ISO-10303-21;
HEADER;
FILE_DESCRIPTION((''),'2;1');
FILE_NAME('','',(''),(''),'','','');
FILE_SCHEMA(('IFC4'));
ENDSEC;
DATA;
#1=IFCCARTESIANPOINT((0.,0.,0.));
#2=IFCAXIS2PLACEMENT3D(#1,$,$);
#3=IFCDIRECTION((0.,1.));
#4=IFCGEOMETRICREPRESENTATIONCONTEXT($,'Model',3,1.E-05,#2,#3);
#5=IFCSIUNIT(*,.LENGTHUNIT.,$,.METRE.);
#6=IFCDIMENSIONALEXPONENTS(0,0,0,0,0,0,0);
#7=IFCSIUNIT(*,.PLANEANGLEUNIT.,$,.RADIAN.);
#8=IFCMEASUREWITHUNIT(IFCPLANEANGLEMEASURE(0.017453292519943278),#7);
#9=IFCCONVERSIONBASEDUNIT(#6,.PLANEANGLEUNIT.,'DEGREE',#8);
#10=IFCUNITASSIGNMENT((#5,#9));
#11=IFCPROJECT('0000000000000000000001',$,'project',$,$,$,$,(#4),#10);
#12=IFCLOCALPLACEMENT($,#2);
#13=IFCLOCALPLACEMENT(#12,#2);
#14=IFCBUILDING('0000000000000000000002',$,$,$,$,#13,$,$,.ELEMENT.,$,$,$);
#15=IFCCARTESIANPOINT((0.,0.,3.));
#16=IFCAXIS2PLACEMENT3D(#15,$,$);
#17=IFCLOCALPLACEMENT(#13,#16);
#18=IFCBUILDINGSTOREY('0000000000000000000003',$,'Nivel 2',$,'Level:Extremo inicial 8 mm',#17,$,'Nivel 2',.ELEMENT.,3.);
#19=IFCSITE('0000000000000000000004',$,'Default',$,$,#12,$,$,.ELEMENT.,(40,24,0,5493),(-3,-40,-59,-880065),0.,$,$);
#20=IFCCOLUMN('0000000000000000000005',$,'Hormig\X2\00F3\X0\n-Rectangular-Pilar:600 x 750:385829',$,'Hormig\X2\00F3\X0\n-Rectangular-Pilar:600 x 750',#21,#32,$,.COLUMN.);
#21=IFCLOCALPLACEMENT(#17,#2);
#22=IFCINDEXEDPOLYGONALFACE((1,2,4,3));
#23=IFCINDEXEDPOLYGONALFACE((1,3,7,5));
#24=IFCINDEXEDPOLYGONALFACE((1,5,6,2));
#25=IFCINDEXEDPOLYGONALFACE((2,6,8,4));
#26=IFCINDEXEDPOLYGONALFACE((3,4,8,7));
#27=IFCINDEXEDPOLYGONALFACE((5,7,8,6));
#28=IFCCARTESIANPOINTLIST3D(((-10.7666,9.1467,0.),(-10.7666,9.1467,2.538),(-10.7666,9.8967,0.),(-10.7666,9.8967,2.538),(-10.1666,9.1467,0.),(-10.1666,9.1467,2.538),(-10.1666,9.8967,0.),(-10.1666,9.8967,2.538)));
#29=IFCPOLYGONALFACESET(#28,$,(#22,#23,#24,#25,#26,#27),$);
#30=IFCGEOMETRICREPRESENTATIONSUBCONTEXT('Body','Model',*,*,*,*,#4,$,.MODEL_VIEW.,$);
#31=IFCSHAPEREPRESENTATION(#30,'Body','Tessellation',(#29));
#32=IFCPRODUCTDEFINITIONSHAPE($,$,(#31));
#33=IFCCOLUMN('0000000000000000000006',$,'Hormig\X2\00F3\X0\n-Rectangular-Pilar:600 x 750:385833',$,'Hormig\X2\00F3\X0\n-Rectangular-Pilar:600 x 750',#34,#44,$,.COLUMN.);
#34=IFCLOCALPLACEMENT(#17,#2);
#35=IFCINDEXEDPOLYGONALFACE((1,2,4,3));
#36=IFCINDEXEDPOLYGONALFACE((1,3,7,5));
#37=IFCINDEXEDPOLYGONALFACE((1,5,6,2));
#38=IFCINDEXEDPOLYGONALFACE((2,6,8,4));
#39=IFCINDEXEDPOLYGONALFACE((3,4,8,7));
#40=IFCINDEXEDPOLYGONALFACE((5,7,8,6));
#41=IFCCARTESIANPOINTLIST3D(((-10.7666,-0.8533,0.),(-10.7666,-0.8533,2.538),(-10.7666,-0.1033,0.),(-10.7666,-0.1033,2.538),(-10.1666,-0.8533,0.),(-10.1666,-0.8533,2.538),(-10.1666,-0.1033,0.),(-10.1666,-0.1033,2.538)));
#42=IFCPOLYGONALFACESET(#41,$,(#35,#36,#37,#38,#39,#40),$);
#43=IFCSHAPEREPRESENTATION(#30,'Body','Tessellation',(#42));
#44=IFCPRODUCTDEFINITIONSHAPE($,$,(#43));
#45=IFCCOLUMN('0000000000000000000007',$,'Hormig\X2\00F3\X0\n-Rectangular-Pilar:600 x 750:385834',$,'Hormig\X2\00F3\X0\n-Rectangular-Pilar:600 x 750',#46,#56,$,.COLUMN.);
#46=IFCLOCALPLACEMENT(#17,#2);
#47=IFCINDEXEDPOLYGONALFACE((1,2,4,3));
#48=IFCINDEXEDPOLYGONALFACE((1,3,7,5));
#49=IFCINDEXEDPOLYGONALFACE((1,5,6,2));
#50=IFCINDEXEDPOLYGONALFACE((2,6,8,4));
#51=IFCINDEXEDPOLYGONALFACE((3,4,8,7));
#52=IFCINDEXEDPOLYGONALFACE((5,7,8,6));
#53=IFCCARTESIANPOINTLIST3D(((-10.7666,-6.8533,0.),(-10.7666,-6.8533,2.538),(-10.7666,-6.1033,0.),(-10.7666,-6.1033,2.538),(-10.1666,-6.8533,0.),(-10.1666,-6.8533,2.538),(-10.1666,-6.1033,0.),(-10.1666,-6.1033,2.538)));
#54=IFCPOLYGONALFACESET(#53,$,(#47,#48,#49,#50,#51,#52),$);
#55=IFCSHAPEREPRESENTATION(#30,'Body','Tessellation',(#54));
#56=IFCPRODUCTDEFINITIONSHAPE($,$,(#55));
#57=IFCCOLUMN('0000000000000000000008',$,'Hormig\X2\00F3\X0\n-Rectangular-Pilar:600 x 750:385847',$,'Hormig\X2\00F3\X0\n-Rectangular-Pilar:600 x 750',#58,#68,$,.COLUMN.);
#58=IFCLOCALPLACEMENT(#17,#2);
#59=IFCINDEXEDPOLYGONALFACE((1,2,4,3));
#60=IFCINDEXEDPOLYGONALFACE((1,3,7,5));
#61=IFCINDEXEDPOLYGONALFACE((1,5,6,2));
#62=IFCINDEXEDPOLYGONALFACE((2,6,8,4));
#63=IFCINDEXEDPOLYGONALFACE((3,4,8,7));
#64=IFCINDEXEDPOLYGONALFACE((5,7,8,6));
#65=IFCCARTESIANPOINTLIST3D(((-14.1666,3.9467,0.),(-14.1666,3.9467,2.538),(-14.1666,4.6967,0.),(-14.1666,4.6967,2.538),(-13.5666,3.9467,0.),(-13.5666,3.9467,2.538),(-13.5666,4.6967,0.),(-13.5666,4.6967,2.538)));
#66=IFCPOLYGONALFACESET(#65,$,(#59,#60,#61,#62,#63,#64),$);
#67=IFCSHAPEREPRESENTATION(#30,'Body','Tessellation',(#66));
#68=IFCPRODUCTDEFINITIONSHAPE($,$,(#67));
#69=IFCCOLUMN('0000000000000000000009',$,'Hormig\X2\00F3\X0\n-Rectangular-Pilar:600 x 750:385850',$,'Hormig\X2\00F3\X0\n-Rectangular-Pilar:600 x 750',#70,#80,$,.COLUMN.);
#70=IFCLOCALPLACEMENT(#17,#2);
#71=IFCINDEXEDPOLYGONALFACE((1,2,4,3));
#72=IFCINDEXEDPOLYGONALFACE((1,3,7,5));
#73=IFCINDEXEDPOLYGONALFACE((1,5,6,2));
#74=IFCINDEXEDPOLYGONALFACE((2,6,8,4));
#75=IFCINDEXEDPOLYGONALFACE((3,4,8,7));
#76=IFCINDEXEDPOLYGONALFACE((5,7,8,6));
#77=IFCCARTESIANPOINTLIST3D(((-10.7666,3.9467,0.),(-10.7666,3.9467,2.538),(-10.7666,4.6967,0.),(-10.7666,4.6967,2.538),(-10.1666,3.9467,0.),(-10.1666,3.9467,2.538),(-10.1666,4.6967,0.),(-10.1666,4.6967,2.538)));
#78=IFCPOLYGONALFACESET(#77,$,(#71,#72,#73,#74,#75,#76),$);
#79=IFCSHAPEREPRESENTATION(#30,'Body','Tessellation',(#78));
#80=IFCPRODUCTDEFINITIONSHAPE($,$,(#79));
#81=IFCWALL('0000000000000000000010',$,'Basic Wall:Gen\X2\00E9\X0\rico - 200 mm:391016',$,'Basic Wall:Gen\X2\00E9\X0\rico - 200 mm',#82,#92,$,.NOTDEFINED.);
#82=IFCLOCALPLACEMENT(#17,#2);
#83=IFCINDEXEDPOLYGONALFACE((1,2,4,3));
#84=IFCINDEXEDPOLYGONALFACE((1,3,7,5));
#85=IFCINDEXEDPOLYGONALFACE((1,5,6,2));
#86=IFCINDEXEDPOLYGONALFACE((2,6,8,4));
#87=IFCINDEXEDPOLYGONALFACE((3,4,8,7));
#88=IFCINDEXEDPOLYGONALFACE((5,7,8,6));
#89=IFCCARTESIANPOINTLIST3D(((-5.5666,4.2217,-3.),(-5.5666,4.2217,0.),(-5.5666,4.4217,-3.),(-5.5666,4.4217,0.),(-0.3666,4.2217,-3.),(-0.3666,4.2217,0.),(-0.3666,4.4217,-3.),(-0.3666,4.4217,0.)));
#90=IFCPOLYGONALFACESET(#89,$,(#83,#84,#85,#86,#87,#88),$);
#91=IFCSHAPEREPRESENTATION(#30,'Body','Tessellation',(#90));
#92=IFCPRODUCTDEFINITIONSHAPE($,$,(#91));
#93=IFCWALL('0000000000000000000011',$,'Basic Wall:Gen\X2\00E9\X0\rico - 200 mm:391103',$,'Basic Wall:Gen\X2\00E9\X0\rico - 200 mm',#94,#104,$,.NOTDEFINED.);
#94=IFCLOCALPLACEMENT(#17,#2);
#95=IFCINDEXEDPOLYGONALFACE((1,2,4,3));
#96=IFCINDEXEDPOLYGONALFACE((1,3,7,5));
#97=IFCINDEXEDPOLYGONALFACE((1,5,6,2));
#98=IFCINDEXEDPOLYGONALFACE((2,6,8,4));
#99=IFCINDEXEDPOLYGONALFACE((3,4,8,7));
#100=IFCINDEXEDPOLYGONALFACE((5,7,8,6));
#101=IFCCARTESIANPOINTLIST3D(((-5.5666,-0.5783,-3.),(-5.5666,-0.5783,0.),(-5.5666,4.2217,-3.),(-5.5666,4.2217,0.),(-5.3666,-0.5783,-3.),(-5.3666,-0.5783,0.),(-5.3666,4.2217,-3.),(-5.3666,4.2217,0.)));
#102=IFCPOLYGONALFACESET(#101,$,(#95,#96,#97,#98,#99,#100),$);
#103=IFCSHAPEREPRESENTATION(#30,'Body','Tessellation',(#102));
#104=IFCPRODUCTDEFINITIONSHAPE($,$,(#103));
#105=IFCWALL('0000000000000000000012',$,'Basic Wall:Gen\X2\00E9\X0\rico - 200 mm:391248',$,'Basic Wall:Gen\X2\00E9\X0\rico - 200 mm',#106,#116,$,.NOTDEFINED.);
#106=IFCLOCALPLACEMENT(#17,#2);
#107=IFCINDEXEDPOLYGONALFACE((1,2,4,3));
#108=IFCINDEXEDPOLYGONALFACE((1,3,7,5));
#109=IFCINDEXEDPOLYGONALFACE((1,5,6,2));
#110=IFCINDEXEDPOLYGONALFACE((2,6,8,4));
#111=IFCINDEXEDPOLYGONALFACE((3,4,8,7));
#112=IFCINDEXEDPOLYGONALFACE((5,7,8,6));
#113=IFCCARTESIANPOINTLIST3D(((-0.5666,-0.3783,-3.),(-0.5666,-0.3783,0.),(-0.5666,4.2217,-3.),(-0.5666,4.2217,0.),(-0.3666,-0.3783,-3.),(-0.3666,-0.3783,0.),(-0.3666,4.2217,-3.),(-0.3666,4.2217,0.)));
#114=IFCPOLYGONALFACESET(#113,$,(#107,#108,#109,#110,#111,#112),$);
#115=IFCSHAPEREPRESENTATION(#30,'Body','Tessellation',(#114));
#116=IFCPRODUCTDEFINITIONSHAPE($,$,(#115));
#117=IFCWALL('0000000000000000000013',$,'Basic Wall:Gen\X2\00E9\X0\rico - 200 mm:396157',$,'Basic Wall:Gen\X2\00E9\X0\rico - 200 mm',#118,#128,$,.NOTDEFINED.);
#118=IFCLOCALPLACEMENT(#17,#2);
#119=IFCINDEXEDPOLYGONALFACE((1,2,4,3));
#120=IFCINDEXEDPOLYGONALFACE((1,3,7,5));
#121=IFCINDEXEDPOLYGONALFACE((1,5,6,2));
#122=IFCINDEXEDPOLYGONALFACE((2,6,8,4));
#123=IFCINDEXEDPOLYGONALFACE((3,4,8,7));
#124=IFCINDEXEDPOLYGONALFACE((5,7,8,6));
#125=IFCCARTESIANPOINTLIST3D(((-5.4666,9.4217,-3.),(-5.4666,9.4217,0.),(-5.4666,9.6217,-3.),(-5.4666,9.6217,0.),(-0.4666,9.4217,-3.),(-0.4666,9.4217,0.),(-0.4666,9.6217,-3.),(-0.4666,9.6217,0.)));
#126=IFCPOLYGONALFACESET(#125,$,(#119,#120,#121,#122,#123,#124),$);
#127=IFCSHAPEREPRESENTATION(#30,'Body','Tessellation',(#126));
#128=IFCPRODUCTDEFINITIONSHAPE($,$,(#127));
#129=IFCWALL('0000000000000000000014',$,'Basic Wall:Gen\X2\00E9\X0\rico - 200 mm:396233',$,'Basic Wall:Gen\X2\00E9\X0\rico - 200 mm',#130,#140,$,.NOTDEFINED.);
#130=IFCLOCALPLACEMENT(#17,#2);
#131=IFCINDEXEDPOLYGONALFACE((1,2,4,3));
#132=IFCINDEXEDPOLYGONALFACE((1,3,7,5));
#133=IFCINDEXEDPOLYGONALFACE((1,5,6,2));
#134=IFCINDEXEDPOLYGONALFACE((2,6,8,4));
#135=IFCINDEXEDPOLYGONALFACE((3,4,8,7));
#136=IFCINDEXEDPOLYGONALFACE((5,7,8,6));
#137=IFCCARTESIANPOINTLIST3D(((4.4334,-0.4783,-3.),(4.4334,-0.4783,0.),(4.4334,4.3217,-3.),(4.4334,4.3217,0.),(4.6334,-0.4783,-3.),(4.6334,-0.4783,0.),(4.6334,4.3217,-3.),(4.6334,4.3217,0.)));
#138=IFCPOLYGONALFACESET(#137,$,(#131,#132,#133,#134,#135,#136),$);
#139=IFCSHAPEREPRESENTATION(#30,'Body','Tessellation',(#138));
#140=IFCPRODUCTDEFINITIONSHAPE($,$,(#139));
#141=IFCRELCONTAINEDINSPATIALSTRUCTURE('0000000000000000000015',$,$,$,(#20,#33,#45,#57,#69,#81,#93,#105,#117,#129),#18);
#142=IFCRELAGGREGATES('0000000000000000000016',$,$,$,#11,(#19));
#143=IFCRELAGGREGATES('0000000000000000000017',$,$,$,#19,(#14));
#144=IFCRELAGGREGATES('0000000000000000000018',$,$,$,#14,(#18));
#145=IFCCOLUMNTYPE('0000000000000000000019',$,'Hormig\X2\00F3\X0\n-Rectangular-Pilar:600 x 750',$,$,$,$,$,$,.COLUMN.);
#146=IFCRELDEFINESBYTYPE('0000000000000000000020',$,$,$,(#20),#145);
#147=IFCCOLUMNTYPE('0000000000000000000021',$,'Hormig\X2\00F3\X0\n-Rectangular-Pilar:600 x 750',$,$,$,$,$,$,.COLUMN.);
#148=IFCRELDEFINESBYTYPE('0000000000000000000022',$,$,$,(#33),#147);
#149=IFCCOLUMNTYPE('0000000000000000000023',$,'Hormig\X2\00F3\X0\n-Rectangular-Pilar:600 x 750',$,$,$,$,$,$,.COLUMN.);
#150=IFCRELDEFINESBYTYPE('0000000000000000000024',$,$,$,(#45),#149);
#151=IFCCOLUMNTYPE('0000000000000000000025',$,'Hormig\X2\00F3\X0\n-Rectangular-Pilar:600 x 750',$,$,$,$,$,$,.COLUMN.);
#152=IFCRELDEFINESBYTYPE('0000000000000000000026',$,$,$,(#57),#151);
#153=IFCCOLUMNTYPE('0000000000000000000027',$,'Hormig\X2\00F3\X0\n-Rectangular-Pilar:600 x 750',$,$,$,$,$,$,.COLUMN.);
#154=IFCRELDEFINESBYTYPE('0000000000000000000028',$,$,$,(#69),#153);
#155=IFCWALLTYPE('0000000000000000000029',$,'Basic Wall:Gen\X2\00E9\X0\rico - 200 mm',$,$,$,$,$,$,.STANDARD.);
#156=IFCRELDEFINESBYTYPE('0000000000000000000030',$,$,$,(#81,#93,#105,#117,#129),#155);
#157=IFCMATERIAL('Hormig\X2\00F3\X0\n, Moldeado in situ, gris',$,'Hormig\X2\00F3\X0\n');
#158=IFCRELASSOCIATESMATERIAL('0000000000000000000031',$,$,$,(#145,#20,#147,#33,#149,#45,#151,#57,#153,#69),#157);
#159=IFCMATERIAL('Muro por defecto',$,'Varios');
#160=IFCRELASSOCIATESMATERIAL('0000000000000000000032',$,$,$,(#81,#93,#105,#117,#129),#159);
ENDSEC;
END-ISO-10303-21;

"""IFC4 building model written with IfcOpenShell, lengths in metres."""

from ifc_helpers import new_model, entity, si_unit, converted_unit, direction, frame, origin, place, context, subcontext, project, spatial, indexed_curve, outline, extrude, source, transform, mapped, material, type_object, type_shapes, element, save


model = new_model("IFC4")

# Units and contexts
model_context = context("Model", 3, precision=1e-05, world=origin(), true_north=direction((0.0, 1.0)))
body_context = subcontext(model_context, "Body", "Model", "MODEL_VIEW")
ifc_project = project(units=[si_unit("LENGTHUNIT", "METRE"), converted_unit("PLANEANGLEUNIT", "DEGREE", entity("IfcPlaneAngleMeasure", 0.017453292519943278), si_unit("PLANEANGLEUNIT", "RADIAN"), dimensions=[0, 0, 0, 0, 0, 0, 0])], contexts=[model_context])

# Site, building, storey
site_placement = place(None, origin())
site = spatial("IfcSite", under=ifc_project, at=site_placement, Name="Default", CompositionType="ELEMENT", RefLatitude=(40, 24, 0, 5493), RefLongitude=(-3, -40, -59, -880065), RefElevation=0.0)
building_placement = place(site_placement, origin())
building = spatial("IfcBuilding", under=site, at=building_placement, CompositionType="ELEMENT")
storey_placement = place(building_placement, frame((0.0, 0.0, 3.0)))
storey = spatial("IfcBuildingStorey", under=building, at=storey_placement, Name="Nivel 2", ObjectType="Level:Extremo inicial 8 mm", LongName="Nivel 2", CompositionType="ELEMENT", Elevation=3.0)

# Columns
ifc_material_1 = material(Name="Hormigón, Moldeado in situ, gris", Category="Hormigón")
column_type_1 = type_object("IfcColumnType", Name="Hormigón-Rectangular-Pilar:600 x 750", PredefinedType="COLUMN", material=ifc_material_1)
shared_shape_1 = source(origin(), body_context, "Body", "SweptSolid", [
    extrude(outline(indexed_curve([(-0.3, -0.375), (0.3, -0.375), (0.3, 0.375), (-0.3, 0.375), (-0.3, -0.375)], self_intersect=False)), frame((-10.4666, 9.5217, 3.0), z_axis=(0.0, 0.0, 1.0), x_axis=(-1.0, 0.0, 0.0)), (0.0, 0.0, 1.0), 2.538),
])
type_shapes(column_type_1, [shared_shape_1])
column_1_placement = place(storey_placement, frame((0.0, 0.0, -3.0)))
element("IfcColumn", 1, at=column_1_placement, inside=storey, type_object=column_type_1, material=ifc_material_1, Name="Hormigón-Rectangular-Pilar:600 x 750:385829", ObjectType="Hormigón-Rectangular-Pilar:600 x 750", PredefinedType="COLUMN", context=body_context, shape_type="MappedRepresentation", body=[
    mapped(shared_shape_1, transform((0.0, 0.0, 0.0), scale=1.0)),
])
column_type_2 = type_object("IfcColumnType", Name="Hormigón-Rectangular-Pilar:600 x 750", PredefinedType="COLUMN", material=ifc_material_1)
shared_shape_2 = source(origin(), body_context, "Body", "SweptSolid", [
    extrude(outline(indexed_curve([(-0.3, -0.375), (0.3, -0.375), (0.3, 0.375), (-0.3, 0.375), (-0.3, -0.375)], self_intersect=False)), frame((-10.4666, -0.4783, 3.0), z_axis=(0.0, 0.0, 1.0), x_axis=(-1.0, 0.0, 0.0)), (0.0, 0.0, 1.0), 2.538),
])
type_shapes(column_type_2, [shared_shape_2])
column_2_placement = place(storey_placement, frame((0.0, 0.0, -3.0)))
element("IfcColumn", 2, at=column_2_placement, inside=storey, type_object=column_type_2, material=ifc_material_1, Name="Hormigón-Rectangular-Pilar:600 x 750:385833", ObjectType="Hormigón-Rectangular-Pilar:600 x 750", PredefinedType="COLUMN", context=body_context, shape_type="MappedRepresentation", body=[
    mapped(shared_shape_2, transform((0.0, 0.0, 0.0), scale=1.0)),
])
column_type_3 = type_object("IfcColumnType", Name="Hormigón-Rectangular-Pilar:600 x 750", PredefinedType="COLUMN", material=ifc_material_1)
shared_shape_3 = source(origin(), body_context, "Body", "SweptSolid", [
    extrude(outline(indexed_curve([(-0.3, -0.375), (0.3, -0.375), (0.3, 0.375), (-0.3, 0.375), (-0.3, -0.375)], self_intersect=False)), frame((-10.4666, -6.4783, 3.0), z_axis=(0.0, 0.0, 1.0), x_axis=(-1.0, 0.0, 0.0)), (0.0, 0.0, 1.0), 2.538),
])
type_shapes(column_type_3, [shared_shape_3])
column_3_placement = place(storey_placement, frame((0.0, 0.0, -3.0)))
element("IfcColumn", 3, at=column_3_placement, inside=storey, type_object=column_type_3, material=ifc_material_1, Name="Hormigón-Rectangular-Pilar:600 x 750:385834", ObjectType="Hormigón-Rectangular-Pilar:600 x 750", PredefinedType="COLUMN", context=body_context, shape_type="MappedRepresentation", body=[
    mapped(shared_shape_3, transform((0.0, 0.0, 0.0), scale=1.0)),
])
column_type_4 = type_object("IfcColumnType", Name="Hormigón-Rectangular-Pilar:600 x 750", PredefinedType="COLUMN", material=ifc_material_1)
shared_shape_4 = source(origin(), body_context, "Body", "SweptSolid", [
    extrude(outline(indexed_curve([(-0.3, -0.375), (0.3, -0.375), (0.3, 0.375), (-0.3, 0.375), (-0.3, -0.375)], self_intersect=False)), frame((-13.8666, 4.3217, 3.0), z_axis=(0.0, 0.0, 1.0), x_axis=(-1.0, 0.0, 0.0)), (0.0, 0.0, 1.0), 2.538),
])
type_shapes(column_type_4, [shared_shape_4])
column_4_placement = place(storey_placement, frame((0.0, 0.0, -3.0)))
element("IfcColumn", 4, at=column_4_placement, inside=storey, type_object=column_type_4, material=ifc_material_1, Name="Hormigón-Rectangular-Pilar:600 x 750:385847", ObjectType="Hormigón-Rectangular-Pilar:600 x 750", PredefinedType="COLUMN", context=body_context, shape_type="MappedRepresentation", body=[
    mapped(shared_shape_4, transform((0.0, 0.0, 0.0), scale=1.0)),
])
column_type_5 = type_object("IfcColumnType", Name="Hormigón-Rectangular-Pilar:600 x 750", PredefinedType="COLUMN", material=ifc_material_1)
shared_shape_5 = source(origin(), body_context, "Body", "SweptSolid", [
    extrude(outline(indexed_curve([(-0.3, -0.375), (0.3, -0.375), (0.3, 0.375), (-0.3, 0.375), (-0.3, -0.375)], self_intersect=False)), frame((-10.4666, 4.3217, 3.0), z_axis=(0.0, 0.0, 1.0), x_axis=(-1.0, 0.0, 0.0)), (0.0, 0.0, 1.0), 2.538),
])
type_shapes(column_type_5, [shared_shape_5])
column_5_placement = place(storey_placement, frame((0.0, 0.0, -3.0)))
element("IfcColumn", 5, at=column_5_placement, inside=storey, type_object=column_type_5, material=ifc_material_1, Name="Hormigón-Rectangular-Pilar:600 x 750:385850", ObjectType="Hormigón-Rectangular-Pilar:600 x 750", PredefinedType="COLUMN", context=body_context, shape_type="MappedRepresentation", body=[
    mapped(shared_shape_5, transform((0.0, 0.0, 0.0), scale=1.0)),
])

# Walls
ifc_material_2 = material(Name="Muro por defecto", Category="Varios")
wall_type = type_object("IfcWallType", Name="Basic Wall:Genérico - 200 mm", PredefinedType="STANDARD")
wall_1_placement = place(storey_placement, frame((-5.5666, 4.3217, -3.0)))
element("IfcWall", 6, at=wall_1_placement, inside=storey, type_object=wall_type, material=ifc_material_2, Name="Basic Wall:Genérico - 200 mm:391016", ObjectType="Basic Wall:Genérico - 200 mm", PredefinedType="NOTDEFINED", context=body_context, shape_type="SweptSolid", body=[
    extrude(outline(indexed_curve([(5.2, 0.1), (0.0, 0.1), (0.0, -0.1), (5.2, -0.1), (5.2, 0.1)], self_intersect=False)), origin(), (0.0, 0.0, 1.0), 3.0),
])
wall_2_placement = place(storey_placement, frame((-5.4666, 4.2217, -3.0), z_axis=(0.0, 0.0, 1.0), x_axis=(0.0, -1.0, 0.0)))
element("IfcWall", 7, at=wall_2_placement, inside=storey, type_object=wall_type, material=ifc_material_2, Name="Basic Wall:Genérico - 200 mm:391103", ObjectType="Basic Wall:Genérico - 200 mm", PredefinedType="NOTDEFINED", context=body_context, shape_type="SweptSolid", body=[
    extrude(outline(indexed_curve([(4.8, 0.1), (0.0, 0.1), (0.0, -0.1), (4.8, -0.1), (4.8, 0.1)], self_intersect=False)), origin(), (0.0, 0.0, 1.0), 3.0),
])
wall_3_placement = place(storey_placement, frame((-0.4666, 4.2217, -3.0), z_axis=(0.0, 0.0, 1.0), x_axis=(0.0, -1.0, 0.0)))
element("IfcWall", 8, at=wall_3_placement, inside=storey, type_object=wall_type, material=ifc_material_2, Name="Basic Wall:Genérico - 200 mm:391248", ObjectType="Basic Wall:Genérico - 200 mm", PredefinedType="NOTDEFINED", context=body_context, shape_type="SweptSolid", body=[
    extrude(outline(indexed_curve([(4.6, 0.1), (0.0, 0.1), (0.0, -0.1), (4.6, -0.1), (4.6, 0.1)], self_intersect=False)), origin(), (0.0, 0.0, 1.0), 3.0),
])
wall_4_placement = place(storey_placement, frame((-5.4666, 9.5217, -3.0)))
element("IfcWall", 9, at=wall_4_placement, inside=storey, type_object=wall_type, material=ifc_material_2, Name="Basic Wall:Genérico - 200 mm:396157", ObjectType="Basic Wall:Genérico - 200 mm", PredefinedType="NOTDEFINED", context=body_context, shape_type="SweptSolid", body=[
    extrude(outline(indexed_curve([(5.0, 0.1), (0.0, 0.1), (0.0, -0.1), (5.0, -0.1), (5.0, 0.1)], self_intersect=False)), origin(), (0.0, 0.0, 1.0), 3.0),
])
wall_5_placement = place(storey_placement, frame((4.5334, 4.3217, -3.0), z_axis=(0.0, 0.0, 1.0), x_axis=(0.0, -1.0, 0.0)))
element("IfcWall", 10, at=wall_5_placement, inside=storey, type_object=wall_type, material=ifc_material_2, Name="Basic Wall:Genérico - 200 mm:396233", ObjectType="Basic Wall:Genérico - 200 mm", PredefinedType="NOTDEFINED", context=body_context, shape_type="SweptSolid", body=[
    extrude(outline(indexed_curve([(4.8, 0.1), (0.0, 0.1), (0.0, -0.1), (4.8, -0.1), (4.8, 0.1)], self_intersect=False)), origin(), (0.0, 0.0, 1.0), 3.0),
])

save(model, "model.ifc")
